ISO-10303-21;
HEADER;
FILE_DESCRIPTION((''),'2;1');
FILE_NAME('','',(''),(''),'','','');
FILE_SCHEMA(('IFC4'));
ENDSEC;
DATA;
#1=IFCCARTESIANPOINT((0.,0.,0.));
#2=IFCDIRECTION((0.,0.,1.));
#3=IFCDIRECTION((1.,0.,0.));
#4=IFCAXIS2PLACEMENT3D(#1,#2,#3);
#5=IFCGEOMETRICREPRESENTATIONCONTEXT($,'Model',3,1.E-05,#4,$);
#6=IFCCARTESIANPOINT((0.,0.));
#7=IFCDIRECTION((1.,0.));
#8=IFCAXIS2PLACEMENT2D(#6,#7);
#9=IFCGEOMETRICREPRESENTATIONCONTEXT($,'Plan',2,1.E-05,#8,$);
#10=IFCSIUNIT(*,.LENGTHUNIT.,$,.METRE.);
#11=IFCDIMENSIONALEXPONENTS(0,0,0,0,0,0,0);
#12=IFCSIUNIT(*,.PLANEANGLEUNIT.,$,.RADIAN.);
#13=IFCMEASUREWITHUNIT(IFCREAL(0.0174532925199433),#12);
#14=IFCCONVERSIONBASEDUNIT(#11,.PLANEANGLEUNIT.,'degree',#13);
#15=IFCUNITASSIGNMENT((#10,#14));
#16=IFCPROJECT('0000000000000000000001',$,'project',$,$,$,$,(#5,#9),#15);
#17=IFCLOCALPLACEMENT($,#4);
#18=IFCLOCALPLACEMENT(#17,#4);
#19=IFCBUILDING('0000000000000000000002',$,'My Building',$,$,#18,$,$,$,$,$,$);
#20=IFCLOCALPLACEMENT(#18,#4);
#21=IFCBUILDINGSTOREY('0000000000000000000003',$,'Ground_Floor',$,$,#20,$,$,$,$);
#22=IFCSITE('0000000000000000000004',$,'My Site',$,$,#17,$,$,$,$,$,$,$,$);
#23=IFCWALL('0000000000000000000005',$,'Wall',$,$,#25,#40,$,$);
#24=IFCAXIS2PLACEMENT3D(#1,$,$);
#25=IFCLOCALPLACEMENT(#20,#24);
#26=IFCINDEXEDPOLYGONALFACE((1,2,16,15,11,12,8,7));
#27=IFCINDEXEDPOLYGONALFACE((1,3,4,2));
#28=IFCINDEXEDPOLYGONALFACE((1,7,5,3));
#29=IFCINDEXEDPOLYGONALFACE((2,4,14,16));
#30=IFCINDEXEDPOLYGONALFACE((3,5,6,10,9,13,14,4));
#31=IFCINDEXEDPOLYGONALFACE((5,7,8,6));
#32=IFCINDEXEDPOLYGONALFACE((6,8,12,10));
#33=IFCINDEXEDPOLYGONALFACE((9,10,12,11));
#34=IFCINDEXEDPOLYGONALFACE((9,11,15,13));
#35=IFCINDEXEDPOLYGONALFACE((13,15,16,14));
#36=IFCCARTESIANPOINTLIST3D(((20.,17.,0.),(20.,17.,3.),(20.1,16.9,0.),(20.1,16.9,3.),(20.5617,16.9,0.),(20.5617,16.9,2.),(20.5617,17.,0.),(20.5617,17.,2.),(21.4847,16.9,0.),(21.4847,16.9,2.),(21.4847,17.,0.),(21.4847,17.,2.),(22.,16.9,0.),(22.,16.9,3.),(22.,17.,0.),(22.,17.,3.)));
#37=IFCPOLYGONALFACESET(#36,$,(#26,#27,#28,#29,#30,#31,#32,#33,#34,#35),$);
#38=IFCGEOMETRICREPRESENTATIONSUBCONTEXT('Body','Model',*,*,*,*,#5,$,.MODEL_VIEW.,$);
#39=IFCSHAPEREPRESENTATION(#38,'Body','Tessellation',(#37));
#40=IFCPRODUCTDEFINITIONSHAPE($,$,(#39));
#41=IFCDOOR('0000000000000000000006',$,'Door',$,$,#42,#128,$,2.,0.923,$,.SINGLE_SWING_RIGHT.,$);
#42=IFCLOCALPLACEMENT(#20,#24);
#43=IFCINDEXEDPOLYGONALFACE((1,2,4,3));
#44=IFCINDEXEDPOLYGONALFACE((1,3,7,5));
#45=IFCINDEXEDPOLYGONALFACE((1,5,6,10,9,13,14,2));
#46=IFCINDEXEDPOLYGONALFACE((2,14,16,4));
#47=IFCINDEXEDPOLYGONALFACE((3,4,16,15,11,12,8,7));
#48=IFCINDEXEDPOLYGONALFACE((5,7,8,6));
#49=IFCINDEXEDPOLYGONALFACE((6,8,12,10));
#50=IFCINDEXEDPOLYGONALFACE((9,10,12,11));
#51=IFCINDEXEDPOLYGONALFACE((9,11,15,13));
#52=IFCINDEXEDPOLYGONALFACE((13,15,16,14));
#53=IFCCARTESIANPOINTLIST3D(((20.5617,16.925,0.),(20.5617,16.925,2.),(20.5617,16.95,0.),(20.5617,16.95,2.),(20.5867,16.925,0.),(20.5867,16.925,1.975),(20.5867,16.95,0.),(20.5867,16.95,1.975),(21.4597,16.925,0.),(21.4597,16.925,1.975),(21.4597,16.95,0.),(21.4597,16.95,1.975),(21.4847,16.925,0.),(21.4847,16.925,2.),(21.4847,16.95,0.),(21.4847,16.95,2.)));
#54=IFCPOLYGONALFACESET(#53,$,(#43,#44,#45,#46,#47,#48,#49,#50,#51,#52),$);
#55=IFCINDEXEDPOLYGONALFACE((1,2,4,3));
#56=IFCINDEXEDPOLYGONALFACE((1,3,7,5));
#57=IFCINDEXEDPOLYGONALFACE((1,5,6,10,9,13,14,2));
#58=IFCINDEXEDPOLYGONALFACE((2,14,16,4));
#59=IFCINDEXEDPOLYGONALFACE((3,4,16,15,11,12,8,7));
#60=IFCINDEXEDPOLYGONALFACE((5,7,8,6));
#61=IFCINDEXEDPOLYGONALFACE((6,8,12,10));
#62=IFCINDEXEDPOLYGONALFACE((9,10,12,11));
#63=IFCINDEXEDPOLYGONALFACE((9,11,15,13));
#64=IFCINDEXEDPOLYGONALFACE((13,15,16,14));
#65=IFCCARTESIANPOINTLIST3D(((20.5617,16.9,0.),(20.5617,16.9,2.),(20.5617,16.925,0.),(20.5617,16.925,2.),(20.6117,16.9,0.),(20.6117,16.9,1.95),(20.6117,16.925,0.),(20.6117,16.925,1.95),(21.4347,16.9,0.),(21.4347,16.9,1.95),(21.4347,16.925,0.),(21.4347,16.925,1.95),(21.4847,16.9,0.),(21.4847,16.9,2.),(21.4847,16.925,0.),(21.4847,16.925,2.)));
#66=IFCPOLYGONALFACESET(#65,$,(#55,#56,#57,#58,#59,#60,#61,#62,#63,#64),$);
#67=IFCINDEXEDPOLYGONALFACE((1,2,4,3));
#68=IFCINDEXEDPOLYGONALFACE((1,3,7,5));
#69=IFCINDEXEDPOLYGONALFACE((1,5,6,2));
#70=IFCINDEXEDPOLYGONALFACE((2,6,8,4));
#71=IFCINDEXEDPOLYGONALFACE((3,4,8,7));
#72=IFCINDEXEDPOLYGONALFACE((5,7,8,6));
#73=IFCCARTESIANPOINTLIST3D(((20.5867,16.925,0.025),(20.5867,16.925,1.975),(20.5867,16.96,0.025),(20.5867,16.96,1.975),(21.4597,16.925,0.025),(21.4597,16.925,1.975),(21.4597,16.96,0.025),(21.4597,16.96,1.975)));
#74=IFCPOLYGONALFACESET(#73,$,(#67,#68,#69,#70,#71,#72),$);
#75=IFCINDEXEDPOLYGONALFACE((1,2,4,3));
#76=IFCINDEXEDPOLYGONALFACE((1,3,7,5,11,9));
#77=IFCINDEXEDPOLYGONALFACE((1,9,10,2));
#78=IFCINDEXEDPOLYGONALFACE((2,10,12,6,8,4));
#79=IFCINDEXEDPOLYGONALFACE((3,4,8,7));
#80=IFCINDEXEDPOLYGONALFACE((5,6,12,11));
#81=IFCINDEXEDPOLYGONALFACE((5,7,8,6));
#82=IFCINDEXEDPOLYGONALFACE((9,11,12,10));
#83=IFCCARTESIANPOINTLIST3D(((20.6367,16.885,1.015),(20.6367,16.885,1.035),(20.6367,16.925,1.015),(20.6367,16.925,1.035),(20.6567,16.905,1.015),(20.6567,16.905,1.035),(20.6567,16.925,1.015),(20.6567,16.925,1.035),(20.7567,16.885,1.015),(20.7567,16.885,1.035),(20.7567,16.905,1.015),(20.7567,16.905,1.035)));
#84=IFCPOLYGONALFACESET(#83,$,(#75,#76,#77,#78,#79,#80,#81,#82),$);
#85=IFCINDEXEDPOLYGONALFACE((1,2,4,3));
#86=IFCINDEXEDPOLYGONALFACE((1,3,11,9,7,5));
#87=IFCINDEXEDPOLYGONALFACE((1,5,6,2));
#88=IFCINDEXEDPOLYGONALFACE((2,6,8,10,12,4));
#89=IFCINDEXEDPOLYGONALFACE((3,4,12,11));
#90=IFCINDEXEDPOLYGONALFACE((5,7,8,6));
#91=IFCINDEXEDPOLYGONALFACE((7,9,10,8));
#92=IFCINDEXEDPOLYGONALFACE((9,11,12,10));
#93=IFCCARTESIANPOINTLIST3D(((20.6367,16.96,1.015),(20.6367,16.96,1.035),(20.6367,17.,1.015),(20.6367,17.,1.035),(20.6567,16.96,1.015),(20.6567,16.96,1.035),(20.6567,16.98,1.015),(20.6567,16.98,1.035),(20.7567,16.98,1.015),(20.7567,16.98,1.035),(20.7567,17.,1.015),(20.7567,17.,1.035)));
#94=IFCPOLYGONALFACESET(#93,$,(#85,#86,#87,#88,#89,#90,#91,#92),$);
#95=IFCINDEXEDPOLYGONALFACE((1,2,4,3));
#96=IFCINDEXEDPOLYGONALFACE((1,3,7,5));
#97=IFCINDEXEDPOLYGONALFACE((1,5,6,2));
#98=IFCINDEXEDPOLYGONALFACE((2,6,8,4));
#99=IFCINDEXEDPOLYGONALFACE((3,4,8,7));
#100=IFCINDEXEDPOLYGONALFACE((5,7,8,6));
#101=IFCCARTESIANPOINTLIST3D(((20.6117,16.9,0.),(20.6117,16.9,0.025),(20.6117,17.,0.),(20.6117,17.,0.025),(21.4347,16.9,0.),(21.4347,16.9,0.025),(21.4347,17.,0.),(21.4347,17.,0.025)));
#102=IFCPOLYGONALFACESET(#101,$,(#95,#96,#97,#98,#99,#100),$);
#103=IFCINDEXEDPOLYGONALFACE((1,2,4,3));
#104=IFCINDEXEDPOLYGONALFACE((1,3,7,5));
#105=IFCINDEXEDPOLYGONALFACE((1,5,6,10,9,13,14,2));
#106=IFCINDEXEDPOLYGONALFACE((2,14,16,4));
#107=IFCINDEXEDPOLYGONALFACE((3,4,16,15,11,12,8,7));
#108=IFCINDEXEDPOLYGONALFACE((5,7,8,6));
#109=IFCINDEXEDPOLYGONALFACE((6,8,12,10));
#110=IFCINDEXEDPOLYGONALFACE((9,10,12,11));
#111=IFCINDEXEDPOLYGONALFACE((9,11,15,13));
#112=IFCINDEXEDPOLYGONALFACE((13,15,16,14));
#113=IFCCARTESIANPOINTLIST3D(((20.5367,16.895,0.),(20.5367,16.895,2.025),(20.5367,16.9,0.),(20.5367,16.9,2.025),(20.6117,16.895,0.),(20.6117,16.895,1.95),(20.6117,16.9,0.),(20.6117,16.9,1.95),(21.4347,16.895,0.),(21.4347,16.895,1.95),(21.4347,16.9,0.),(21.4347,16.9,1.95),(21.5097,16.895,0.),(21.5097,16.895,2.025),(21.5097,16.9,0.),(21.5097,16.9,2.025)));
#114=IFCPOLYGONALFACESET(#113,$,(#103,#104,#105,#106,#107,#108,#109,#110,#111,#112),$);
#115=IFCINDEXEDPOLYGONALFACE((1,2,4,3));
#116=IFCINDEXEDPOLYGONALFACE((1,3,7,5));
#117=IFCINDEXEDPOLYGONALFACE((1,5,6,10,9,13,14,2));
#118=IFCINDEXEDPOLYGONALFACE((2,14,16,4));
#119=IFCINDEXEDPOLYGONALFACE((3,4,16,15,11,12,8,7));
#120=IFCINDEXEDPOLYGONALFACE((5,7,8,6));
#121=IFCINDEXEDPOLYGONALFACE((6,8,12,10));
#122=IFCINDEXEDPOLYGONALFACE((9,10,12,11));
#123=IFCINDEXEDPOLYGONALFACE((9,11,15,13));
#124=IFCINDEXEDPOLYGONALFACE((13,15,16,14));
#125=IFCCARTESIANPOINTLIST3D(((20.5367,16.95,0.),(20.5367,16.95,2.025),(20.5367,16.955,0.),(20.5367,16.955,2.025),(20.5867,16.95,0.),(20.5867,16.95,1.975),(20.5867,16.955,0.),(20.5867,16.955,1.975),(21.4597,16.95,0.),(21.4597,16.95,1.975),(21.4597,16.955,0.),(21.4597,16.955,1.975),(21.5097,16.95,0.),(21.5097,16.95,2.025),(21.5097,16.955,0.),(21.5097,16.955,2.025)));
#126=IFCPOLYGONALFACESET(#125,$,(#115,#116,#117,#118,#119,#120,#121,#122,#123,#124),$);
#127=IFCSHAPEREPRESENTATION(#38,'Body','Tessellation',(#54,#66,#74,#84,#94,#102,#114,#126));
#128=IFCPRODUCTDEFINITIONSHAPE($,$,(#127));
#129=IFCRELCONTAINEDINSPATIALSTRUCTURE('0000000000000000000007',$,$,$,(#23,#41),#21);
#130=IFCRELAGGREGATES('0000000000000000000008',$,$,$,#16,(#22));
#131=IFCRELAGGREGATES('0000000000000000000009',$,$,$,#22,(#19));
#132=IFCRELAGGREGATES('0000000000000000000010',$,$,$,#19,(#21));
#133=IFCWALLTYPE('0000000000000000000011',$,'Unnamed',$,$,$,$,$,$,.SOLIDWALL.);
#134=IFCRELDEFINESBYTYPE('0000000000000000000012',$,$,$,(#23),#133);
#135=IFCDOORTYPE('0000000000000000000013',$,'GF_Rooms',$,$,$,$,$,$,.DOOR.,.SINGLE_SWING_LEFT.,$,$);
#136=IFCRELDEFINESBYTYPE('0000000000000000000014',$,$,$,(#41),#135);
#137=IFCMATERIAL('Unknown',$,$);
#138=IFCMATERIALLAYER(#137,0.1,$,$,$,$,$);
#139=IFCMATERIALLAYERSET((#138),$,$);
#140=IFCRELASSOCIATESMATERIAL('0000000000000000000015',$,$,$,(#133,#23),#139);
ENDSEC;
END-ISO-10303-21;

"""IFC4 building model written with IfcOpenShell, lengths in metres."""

from ifc_helpers import new_model, entity, si_unit, converted_unit, frame, origin_with_axes, origin_2d_with_axis, place, context, subcontext, project, spatial, line, indexed_curve, outline, extrude, shape, source, transform, mapped, material, layer, layer_set, layer_usage, type_object, type_shapes, element, fill, save


model = new_model("IFC4")

# Units and contexts
model_context = context("Model", 3, precision=1e-05, world=origin_with_axes())
plan_context = context("Plan", 2, precision=1e-05, world=origin_2d_with_axis())
body_context_1 = subcontext(model_context, "Body", "Model", "MODEL_VIEW")
body_context_2 = subcontext(plan_context, "Body", "Plan", "PLAN_VIEW")
ifc_project = project(units=[si_unit("LENGTHUNIT", "METRE"), converted_unit("PLANEANGLEUNIT", "degree", entity("IfcReal", 0.0174532925199433), si_unit("PLANEANGLEUNIT", "RADIAN"), dimensions=[0, 0, 0, 0, 0, 0, 0])], contexts=[model_context, plan_context])

# Site, building, storey
site_placement = place(None, origin_with_axes())
site = spatial("IfcSite", under=ifc_project, at=site_placement, Name="My Site")
building_placement = place(site_placement, origin_with_axes())
building = spatial("IfcBuilding", under=site, at=building_placement, Name="My Building")
storey_placement = place(building_placement, origin_with_axes())
storey = spatial("IfcBuildingStorey", under=building, at=storey_placement, Name="Ground_Floor")

# Shared definitions
ifc_material = material(Name="Unknown")
ifc_layer = layer(ifc_material, 0.1)
ifc_layer_set = layer_set([ifc_layer])
wall_type = type_object("IfcWallType", Name="Unnamed", PredefinedType="SOLIDWALL", material=ifc_layer_set)

# Wall, opening, door
ifc_layer_usage_1 = layer_usage(ifc_layer_set, "AXIS2", "POSITIVE", 0.0)
wall_1_placement = place(storey_placement, frame((22.0, 17.0, 0.0), z_axis=(0.0, 0.0, 1.0), x_axis=(-1.0, 0.0, 0.0)))
wall_1 = element("IfcWall", 1, at=wall_1_placement, inside=storey, type_object=wall_type, material=ifc_layer_usage_1, Name="Wall", context=body_context_1, shape_type="SweptSolid", body=[
    extrude(outline(indexed_curve([(0.0, 0.0), (0.0, 0.1), (1.9, 0.1), (2.0, 0.0)], segments=[line(1, 2, 3, 4, 1)])), origin_with_axes(), (0.0, 0.0, 1.0), 3.0),
])
shared_shape_1 = source(origin_with_axes(), body_context_1, "Body", "SweptSolid", [
    extrude(outline(indexed_curve([(0.0, 0.0), (0.923, 0.0), (0.923, 2.0), (0.0, 2.0)], segments=[line(1, 2, 3, 4, 1)])), frame((0.0, -0.6, 0.0), z_axis=(0.0, -1.0, 0.0), x_axis=(1.0, 0.0, 0.0)), (0.0, 0.0, -1.0), 1.2),
])
opening_1_placement = place(wall_1_placement, frame((1.4383, 0.1, 0.0), z_axis=(0.0, 0.0, 1.0), x_axis=(-1.0, 0.0, 0.0)))
opening_1 = element("IfcOpeningElement", 2, at=opening_1_placement, cuts=wall_1, PredefinedType="OPENING", context=body_context_1, shape_type="MappedRepresentation", body=[
    mapped(shared_shape_1, transform((0.0, 0.0, 0.0), x_axis=(1.0, 0.0, 0.0), y_axis=(0.0, 1.0, 0.0), z_axis=(0.0, 0.0, 1.0), scale=1.0)),
])
door_type_1 = type_object("IfcDoorType", Name="GF_Rooms", OperationType="SINGLE_SWING_LEFT", PredefinedType="DOOR")
shared_shape_2 = source(origin_with_axes(), body_context_1, "Body", "SweptSolid", [
    extrude(outline(indexed_curve([(0.0, 0.0), (0.0, 2.0), (0.923, 2.0), (0.923, 0.0), (0.898, 0.0), (0.898, 1.975), (0.025, 1.975), (0.025, 0.0)], segments=[line(1, 2, 3, 4, 5, 6, 7, 8, 1)])), frame((0.0, 0.025, 0.0), z_axis=(0.0, -1.0, 0.0), x_axis=(1.0, 0.0, 0.0)), (0.0, 0.0, -1.0), 0.025),
    extrude(outline(indexed_curve([(0.0, 0.0), (0.0, 2.0), (0.923, 2.0), (0.923, 0.0), (0.873, 0.0), (0.873, 1.95), (0.05, 1.95), (0.05, 0.0)], segments=[line(1, 2, 3, 4, 5, 6, 7, 8, 1)])), frame((0.0, 0.0, 0.0), z_axis=(0.0, -1.0, 0.0), x_axis=(1.0, 0.0, 0.0)), (0.0, 0.0, -1.0), 0.025),
    extrude(outline(indexed_curve([(0.0, 0.0), (0.873, 0.0), (0.873, 0.035), (0.0, 0.035)], segments=[line(1, 2, 3, 4, 1)])), frame((0.025, 0.025, 0.025), z_axis=(0.0, 0.0, 1.0), x_axis=(1.0, 0.0, 0.0)), (0.0, 0.0, 1.0), 1.95),
    extrude(outline(indexed_curve([(0.0, 0.0), (0.0, -0.04), (0.12, -0.04), (0.12, -0.02), (0.02, -0.02), (0.02, 0.0)], segments=[line(1, 2, 3, 4, 5, 6, 1)])), frame((0.075, 0.025, 1.015), z_axis=(0.0, 0.0, 1.0), x_axis=(1.0, 0.0, 0.0)), (0.0, 0.0, 1.0), 0.02),
    extrude(outline(indexed_curve([(0.0, 0.0), (0.0, 0.04), (0.12, 0.04), (0.12, 0.02), (0.02, 0.02), (0.02, 0.0)], segments=[line(1, 2, 3, 4, 5, 6, 1)])), frame((0.075, 0.06, 1.015), z_axis=(0.0, 0.0, 1.0), x_axis=(1.0, 0.0, 0.0)), (0.0, 0.0, 1.0), 0.02),
    extrude(outline(indexed_curve([(0.0, 0.0), (0.823, 0.0), (0.823, 0.1), (0.0, 0.1)], segments=[line(1, 2, 3, 4, 1)])), frame((0.05, 0.0, 0.0), z_axis=(0.0, 0.0, 1.0), x_axis=(1.0, 0.0, 0.0)), (0.0, 0.0, 1.0), 0.025),
    extrude(outline(indexed_curve([(0.0, 0.0), (0.0, 2.025), (0.973, 2.025), (0.973, 0.0), (0.898, 0.0), (0.898, 1.95), (0.075, 1.95), (0.075, 0.0)], segments=[line(1, 2, 3, 4, 5, 6, 7, 8, 1)])), frame((-0.025, -0.005, 0.0), z_axis=(0.0, -1.0, 0.0), x_axis=(1.0, 0.0, 0.0)), (0.0, 0.0, -1.0), 0.005),
    extrude(outline(indexed_curve([(0.0, 0.0), (0.0, 2.025), (0.973, 2.025), (0.973, 0.0), (0.923, 0.0), (0.923, 1.975), (0.05, 1.975), (0.05, 0.0)], segments=[line(1, 2, 3, 4, 5, 6, 7, 8, 1)])), frame((-0.025, 0.05, 0.0), z_axis=(0.0, -1.0, 0.0), x_axis=(1.0, 0.0, 0.0)), (0.0, 0.0, -1.0), 0.005),
])
shared_shape_3 = source(origin_with_axes(), body_context_2, "Body", "Curve2D", [
    entity("IfcIndexedPolyCurve", entity("IfcCartesianPointList2D", [[0.0, 0.0], [0.0, 0.05], [0.025, 0.05], [0.025, 0.025], [0.05, 0.025], [0.05, 0.0]]), [entity("IfcLineIndex", [1, 2, 3, 4, 5, 6, 1])]),
    entity("IfcIndexedPolyCurve", entity("IfcCartesianPointList2D", [[0.923, 0.0], [0.923, 0.05], [0.898, 0.05], [0.898, 0.025], [0.873, 0.025], [0.873, 0.0]]), [entity("IfcLineIndex", [1, 2, 3, 4, 5, 6, 1])]),
    entity("IfcTrimmedCurve", entity("IfcEllipse", entity("IfcAxis2Placement2D", entity("IfcCartesianPoint", [0.863, 0.05]), entity("IfcDirection", [1.0, 0.0])), 0.838, 0.873), [entity("IfcCartesianPoint", [0.863, 0.923])], [entity("IfcCartesianPoint", [0.025, 0.05])], True, "CARTESIAN"),
    entity("IfcIndexedPolyCurve", entity("IfcCartesianPointList2D", [[0.898, 0.05], [0.863, 0.05], [0.863, 0.923], [0.898, 0.923]]), [entity("IfcLineIndex", [1, 2, 3, 4, 1])]),
])
type_shapes(door_type_1, [shared_shape_2, shared_shape_3])
door_1_placement = place(opening_1_placement, frame((0.0, 0.0, 0.0), z_axis=(0.0, 0.0, 1.0), x_axis=(1.0, 0.0, 0.0)))
door_1 = element("IfcDoor", 3, at=door_1_placement, inside=storey, type_object=door_type_1, Name="Door", OperationType="SINGLE_SWING_RIGHT", OverallHeight=2.0, OverallWidth=0.923, shapes=[
    shape(body_context_1, "Body", "MappedRepresentation", [mapped(shared_shape_2, transform((0.0, 0.0, 0.0), x_axis=(1.0, 0.0, 0.0), y_axis=(0.0, 1.0, 0.0), z_axis=(0.0, 0.0, 1.0), scale=1.0))]),
    shape(body_context_2, "Body", "MappedRepresentation", [mapped(shared_shape_3, transform((0.0, 0.0, 0.0), x_axis=(1.0, 0.0, 0.0), y_axis=(0.0, 1.0, 0.0), z_axis=(0.0, 0.0, 1.0), scale=1.0))]),
])
fill(opening_1, door_1)

save(model, "model.ifc")
